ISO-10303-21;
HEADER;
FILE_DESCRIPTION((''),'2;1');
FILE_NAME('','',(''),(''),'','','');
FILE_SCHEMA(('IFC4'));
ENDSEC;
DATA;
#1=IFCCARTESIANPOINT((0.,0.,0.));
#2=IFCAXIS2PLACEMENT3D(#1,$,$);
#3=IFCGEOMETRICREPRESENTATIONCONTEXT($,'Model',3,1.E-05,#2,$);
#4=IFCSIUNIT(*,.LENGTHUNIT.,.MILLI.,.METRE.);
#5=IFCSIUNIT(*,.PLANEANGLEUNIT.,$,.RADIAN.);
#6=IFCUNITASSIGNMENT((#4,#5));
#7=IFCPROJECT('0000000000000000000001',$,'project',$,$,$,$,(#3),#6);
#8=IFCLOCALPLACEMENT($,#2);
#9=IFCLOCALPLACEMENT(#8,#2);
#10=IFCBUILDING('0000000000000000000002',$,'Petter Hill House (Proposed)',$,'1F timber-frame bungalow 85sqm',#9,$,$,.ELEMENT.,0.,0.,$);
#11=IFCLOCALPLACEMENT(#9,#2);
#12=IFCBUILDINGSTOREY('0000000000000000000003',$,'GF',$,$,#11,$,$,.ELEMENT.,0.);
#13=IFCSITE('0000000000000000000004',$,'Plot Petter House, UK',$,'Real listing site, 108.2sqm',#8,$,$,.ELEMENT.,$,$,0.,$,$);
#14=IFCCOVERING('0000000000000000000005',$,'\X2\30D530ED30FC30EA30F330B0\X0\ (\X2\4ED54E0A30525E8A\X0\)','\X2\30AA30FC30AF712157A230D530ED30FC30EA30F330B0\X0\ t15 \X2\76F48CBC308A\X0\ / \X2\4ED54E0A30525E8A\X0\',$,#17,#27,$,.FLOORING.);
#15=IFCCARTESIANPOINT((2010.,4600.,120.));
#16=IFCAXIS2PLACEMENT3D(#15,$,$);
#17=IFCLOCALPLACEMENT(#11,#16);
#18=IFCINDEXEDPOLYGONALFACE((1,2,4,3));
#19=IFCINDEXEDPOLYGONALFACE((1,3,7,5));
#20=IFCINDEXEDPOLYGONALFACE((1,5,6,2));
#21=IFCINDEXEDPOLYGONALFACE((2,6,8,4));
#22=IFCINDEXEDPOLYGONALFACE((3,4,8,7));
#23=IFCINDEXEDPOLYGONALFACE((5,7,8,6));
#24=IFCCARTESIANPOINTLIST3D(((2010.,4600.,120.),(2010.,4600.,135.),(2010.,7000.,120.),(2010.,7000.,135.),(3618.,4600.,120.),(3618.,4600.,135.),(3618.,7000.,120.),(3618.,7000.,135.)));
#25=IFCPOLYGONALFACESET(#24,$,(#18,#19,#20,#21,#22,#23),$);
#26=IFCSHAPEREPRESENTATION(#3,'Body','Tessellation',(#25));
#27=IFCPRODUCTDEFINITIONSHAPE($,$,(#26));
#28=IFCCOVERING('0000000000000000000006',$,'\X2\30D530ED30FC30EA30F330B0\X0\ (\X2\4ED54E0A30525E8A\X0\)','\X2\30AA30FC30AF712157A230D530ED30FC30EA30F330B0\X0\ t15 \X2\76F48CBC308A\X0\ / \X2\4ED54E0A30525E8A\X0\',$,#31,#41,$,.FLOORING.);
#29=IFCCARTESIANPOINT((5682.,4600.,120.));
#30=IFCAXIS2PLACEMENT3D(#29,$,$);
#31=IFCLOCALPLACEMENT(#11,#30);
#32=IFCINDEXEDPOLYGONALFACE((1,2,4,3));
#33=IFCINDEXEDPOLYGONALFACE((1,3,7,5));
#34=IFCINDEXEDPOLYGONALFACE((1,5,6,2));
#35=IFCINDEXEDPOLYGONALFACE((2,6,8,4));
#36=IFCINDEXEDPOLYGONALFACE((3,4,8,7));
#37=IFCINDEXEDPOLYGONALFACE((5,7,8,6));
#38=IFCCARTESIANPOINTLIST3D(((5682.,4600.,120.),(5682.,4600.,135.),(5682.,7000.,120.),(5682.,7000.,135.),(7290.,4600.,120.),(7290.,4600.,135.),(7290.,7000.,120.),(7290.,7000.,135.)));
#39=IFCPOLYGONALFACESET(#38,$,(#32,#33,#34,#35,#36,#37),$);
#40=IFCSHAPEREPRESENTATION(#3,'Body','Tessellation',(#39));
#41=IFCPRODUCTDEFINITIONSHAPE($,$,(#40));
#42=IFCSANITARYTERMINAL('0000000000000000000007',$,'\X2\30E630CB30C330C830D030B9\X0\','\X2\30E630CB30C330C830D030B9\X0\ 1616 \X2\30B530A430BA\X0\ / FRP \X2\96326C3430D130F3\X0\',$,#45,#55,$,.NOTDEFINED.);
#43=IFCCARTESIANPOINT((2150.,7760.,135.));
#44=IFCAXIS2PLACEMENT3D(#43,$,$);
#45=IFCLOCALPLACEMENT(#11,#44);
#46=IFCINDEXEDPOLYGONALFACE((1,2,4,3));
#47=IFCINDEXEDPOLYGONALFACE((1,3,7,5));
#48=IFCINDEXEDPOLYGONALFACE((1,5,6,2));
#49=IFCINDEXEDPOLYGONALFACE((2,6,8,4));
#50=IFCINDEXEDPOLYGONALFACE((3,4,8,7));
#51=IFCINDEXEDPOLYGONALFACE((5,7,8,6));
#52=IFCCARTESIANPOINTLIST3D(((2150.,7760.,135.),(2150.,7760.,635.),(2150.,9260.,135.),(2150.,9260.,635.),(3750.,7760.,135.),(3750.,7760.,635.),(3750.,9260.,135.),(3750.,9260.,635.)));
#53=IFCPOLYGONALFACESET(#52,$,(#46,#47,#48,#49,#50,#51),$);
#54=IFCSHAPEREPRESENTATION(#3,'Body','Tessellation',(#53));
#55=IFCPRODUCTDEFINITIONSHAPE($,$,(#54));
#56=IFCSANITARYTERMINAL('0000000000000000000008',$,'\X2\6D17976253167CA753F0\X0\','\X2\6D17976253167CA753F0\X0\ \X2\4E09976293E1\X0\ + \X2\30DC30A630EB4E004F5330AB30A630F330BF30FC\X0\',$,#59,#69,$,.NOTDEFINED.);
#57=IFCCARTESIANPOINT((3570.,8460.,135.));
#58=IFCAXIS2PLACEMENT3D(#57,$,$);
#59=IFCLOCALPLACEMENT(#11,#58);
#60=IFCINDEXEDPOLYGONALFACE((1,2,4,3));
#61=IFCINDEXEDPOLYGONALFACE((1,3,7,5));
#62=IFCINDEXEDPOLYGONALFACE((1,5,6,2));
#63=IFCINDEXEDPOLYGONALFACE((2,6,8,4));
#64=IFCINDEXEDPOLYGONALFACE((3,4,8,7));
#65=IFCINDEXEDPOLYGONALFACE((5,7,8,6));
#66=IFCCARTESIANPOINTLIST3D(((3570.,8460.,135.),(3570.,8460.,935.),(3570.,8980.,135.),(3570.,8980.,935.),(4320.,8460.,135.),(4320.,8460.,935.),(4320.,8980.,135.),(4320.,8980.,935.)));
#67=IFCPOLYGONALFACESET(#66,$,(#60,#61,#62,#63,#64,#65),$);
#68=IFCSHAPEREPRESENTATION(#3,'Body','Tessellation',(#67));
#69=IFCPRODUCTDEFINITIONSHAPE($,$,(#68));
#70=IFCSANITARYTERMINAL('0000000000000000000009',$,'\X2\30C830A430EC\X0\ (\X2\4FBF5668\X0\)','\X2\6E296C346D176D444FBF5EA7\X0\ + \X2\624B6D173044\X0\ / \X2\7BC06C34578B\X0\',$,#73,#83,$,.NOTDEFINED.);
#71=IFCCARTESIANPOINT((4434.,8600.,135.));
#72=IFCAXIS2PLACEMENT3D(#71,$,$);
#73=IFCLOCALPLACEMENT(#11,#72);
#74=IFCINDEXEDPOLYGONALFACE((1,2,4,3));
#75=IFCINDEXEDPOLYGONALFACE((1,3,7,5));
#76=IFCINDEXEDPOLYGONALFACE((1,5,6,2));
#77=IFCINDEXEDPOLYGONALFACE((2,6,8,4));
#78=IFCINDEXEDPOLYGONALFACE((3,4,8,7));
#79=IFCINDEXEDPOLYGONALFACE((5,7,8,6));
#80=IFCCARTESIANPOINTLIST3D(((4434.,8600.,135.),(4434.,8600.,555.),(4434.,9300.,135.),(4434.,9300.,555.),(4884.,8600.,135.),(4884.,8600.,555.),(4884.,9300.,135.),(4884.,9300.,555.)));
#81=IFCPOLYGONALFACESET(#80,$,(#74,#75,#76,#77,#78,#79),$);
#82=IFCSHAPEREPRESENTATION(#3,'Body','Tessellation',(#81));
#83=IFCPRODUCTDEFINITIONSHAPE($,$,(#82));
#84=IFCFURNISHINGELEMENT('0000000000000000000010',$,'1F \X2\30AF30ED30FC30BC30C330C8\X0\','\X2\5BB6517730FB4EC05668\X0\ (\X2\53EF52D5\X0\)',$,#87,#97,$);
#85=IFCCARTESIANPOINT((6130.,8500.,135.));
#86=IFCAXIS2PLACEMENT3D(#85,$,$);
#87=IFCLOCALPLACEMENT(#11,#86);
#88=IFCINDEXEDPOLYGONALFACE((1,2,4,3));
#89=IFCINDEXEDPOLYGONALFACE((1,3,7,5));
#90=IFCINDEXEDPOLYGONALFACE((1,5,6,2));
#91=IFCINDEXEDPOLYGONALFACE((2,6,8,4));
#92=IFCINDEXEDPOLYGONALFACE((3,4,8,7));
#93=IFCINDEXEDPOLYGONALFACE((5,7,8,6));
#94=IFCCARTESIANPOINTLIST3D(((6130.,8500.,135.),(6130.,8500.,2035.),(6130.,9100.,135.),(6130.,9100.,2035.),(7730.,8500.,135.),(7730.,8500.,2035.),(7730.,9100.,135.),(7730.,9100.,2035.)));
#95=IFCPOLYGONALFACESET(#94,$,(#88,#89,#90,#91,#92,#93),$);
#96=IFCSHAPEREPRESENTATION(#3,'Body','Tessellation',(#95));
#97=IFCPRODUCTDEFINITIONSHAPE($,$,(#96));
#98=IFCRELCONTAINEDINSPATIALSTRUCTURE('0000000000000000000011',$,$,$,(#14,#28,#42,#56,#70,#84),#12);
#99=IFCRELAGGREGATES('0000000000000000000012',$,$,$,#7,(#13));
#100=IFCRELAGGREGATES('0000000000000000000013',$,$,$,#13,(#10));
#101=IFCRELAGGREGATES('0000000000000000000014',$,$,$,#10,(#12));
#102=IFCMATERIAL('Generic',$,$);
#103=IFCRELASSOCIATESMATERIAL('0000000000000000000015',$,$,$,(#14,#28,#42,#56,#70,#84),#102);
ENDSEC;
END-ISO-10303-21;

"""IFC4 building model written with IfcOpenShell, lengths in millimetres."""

from ifc_helpers import new_model, si_unit, frame, frame_2d, origin, place, context, project, spatial, rectangle, extrude, material, element, save


model = new_model("IFC4")

# Units and contexts
model_context = context("Model", 3, precision=1e-05, world=origin())
ifc_project = project(units=[si_unit("LENGTHUNIT", "METRE", prefix="MILLI"), si_unit("PLANEANGLEUNIT", "RADIAN")], contexts=[model_context])

# Site, building, storey
site_placement = place(None, origin())
site = spatial("IfcSite", under=ifc_project, at=site_placement, Name="Plot Petter House, UK", ObjectType="Real listing site, 108.2sqm", CompositionType="ELEMENT", RefElevation=0.0)
building_placement = place(site_placement, origin())
building = spatial("IfcBuilding", under=site, at=building_placement, Name="Petter Hill House (Proposed)", ObjectType="1F timber-frame bungalow 85sqm", CompositionType="ELEMENT", ElevationOfRefHeight=0.0, ElevationOfTerrain=0.0)
storey_placement = place(building_placement, origin())
storey = spatial("IfcBuildingStorey", under=building, at=storey_placement, Name="GF", CompositionType="ELEMENT", Elevation=0.0)

# Coverings
ifc_material_1 = material(Name="Generic")
covering_1_placement = place(storey_placement, frame((2010.0, 4600.0, 120.0)))
element("IfcCovering", 1, at=covering_1_placement, inside=storey, material=ifc_material_1, Name="フローリング (仕上げ床)", Description="オーク無垢フローリング t15 直貼り / 仕上げ床", PredefinedType="FLOORING", context=model_context, shape_type="SweptSolid", body=[
    extrude(rectangle(XDim=1608.0, YDim=2400.0, at=frame_2d((804.0, 1200.0))), frame((2010.0, 4600.0, 120.0)), (0.0, 0.0, 1.0), 15.0),
])
covering_2_placement = place(storey_placement, frame((5682.0, 4600.0, 120.0)))
element("IfcCovering", 2, at=covering_2_placement, inside=storey, material=ifc_material_1, Name="フローリング (仕上げ床)", Description="オーク無垢フローリング t15 直貼り / 仕上げ床", PredefinedType="FLOORING", context=model_context, shape_type="SweptSolid", body=[
    extrude(rectangle(XDim=1608.0, YDim=2400.0, at=frame_2d((804.0, 1200.0))), frame((5682.0, 4600.0, 120.0)), (0.0, 0.0, 1.0), 15.0),
])

# Sanitary terminals
sanitary_terminal_1_placement = place(storey_placement, frame((2150.0, 7760.0, 135.0)))
element("IfcSanitaryTerminal", 3, at=sanitary_terminal_1_placement, inside=storey, material=ifc_material_1, Name="ユニットバス", Description="ユニットバス 1616 サイズ / FRP 防水パン", PredefinedType="NOTDEFINED", context=model_context, shape_type="SweptSolid", body=[
    extrude(rectangle(XDim=1600.0, YDim=1500.0, at=frame_2d((800.0, 750.0))), frame((2150.0, 7760.0, 135.0)), (0.0, 0.0, 1.0), 500.0),
])
sanitary_terminal_2_placement = place(storey_placement, frame((3570.0, 8460.0, 135.0)))
element("IfcSanitaryTerminal", 4, at=sanitary_terminal_2_placement, inside=storey, material=ifc_material_1, Name="洗面化粧台", Description="洗面化粧台 三面鏡 + ボウル一体カウンター", PredefinedType="NOTDEFINED", context=model_context, shape_type="SweptSolid", body=[
    extrude(rectangle(XDim=750.0, YDim=520.0, at=frame_2d((375.0, 260.0))), frame((3570.0, 8460.0, 135.0)), (0.0, 0.0, 1.0), 800.0),
])
sanitary_terminal_3_placement = place(storey_placement, frame((4434.0, 8600.0, 135.0)))
element("IfcSanitaryTerminal", 5, at=sanitary_terminal_3_placement, inside=storey, material=ifc_material_1, Name="トイレ (便器)", Description="温水洗浄便座 + 手洗い / 節水型", PredefinedType="NOTDEFINED", context=model_context, shape_type="SweptSolid", body=[
    extrude(rectangle(XDim=450.0, YDim=700.0, at=frame_2d((225.0, 350.0))), frame((4434.0, 8600.0, 135.0)), (0.0, 0.0, 1.0), 420.0),
])

# Furnishing element
furnishing_placement = place(storey_placement, frame((6130.0, 8500.0, 135.0)))
element("IfcFurnishingElement", 6, at=furnishing_placement, inside=storey, material=ifc_material_1, Name="1F クローゼット", Description="家具・什器 (可動)", context=model_context, shape_type="SweptSolid", body=[
    extrude(rectangle(XDim=1600.0, YDim=600.0, at=frame_2d((800.0, 300.0))), frame((6130.0, 8500.0, 135.0)), (0.0, 0.0, 1.0), 1900.0),
])

save(model, "model.ifc")
